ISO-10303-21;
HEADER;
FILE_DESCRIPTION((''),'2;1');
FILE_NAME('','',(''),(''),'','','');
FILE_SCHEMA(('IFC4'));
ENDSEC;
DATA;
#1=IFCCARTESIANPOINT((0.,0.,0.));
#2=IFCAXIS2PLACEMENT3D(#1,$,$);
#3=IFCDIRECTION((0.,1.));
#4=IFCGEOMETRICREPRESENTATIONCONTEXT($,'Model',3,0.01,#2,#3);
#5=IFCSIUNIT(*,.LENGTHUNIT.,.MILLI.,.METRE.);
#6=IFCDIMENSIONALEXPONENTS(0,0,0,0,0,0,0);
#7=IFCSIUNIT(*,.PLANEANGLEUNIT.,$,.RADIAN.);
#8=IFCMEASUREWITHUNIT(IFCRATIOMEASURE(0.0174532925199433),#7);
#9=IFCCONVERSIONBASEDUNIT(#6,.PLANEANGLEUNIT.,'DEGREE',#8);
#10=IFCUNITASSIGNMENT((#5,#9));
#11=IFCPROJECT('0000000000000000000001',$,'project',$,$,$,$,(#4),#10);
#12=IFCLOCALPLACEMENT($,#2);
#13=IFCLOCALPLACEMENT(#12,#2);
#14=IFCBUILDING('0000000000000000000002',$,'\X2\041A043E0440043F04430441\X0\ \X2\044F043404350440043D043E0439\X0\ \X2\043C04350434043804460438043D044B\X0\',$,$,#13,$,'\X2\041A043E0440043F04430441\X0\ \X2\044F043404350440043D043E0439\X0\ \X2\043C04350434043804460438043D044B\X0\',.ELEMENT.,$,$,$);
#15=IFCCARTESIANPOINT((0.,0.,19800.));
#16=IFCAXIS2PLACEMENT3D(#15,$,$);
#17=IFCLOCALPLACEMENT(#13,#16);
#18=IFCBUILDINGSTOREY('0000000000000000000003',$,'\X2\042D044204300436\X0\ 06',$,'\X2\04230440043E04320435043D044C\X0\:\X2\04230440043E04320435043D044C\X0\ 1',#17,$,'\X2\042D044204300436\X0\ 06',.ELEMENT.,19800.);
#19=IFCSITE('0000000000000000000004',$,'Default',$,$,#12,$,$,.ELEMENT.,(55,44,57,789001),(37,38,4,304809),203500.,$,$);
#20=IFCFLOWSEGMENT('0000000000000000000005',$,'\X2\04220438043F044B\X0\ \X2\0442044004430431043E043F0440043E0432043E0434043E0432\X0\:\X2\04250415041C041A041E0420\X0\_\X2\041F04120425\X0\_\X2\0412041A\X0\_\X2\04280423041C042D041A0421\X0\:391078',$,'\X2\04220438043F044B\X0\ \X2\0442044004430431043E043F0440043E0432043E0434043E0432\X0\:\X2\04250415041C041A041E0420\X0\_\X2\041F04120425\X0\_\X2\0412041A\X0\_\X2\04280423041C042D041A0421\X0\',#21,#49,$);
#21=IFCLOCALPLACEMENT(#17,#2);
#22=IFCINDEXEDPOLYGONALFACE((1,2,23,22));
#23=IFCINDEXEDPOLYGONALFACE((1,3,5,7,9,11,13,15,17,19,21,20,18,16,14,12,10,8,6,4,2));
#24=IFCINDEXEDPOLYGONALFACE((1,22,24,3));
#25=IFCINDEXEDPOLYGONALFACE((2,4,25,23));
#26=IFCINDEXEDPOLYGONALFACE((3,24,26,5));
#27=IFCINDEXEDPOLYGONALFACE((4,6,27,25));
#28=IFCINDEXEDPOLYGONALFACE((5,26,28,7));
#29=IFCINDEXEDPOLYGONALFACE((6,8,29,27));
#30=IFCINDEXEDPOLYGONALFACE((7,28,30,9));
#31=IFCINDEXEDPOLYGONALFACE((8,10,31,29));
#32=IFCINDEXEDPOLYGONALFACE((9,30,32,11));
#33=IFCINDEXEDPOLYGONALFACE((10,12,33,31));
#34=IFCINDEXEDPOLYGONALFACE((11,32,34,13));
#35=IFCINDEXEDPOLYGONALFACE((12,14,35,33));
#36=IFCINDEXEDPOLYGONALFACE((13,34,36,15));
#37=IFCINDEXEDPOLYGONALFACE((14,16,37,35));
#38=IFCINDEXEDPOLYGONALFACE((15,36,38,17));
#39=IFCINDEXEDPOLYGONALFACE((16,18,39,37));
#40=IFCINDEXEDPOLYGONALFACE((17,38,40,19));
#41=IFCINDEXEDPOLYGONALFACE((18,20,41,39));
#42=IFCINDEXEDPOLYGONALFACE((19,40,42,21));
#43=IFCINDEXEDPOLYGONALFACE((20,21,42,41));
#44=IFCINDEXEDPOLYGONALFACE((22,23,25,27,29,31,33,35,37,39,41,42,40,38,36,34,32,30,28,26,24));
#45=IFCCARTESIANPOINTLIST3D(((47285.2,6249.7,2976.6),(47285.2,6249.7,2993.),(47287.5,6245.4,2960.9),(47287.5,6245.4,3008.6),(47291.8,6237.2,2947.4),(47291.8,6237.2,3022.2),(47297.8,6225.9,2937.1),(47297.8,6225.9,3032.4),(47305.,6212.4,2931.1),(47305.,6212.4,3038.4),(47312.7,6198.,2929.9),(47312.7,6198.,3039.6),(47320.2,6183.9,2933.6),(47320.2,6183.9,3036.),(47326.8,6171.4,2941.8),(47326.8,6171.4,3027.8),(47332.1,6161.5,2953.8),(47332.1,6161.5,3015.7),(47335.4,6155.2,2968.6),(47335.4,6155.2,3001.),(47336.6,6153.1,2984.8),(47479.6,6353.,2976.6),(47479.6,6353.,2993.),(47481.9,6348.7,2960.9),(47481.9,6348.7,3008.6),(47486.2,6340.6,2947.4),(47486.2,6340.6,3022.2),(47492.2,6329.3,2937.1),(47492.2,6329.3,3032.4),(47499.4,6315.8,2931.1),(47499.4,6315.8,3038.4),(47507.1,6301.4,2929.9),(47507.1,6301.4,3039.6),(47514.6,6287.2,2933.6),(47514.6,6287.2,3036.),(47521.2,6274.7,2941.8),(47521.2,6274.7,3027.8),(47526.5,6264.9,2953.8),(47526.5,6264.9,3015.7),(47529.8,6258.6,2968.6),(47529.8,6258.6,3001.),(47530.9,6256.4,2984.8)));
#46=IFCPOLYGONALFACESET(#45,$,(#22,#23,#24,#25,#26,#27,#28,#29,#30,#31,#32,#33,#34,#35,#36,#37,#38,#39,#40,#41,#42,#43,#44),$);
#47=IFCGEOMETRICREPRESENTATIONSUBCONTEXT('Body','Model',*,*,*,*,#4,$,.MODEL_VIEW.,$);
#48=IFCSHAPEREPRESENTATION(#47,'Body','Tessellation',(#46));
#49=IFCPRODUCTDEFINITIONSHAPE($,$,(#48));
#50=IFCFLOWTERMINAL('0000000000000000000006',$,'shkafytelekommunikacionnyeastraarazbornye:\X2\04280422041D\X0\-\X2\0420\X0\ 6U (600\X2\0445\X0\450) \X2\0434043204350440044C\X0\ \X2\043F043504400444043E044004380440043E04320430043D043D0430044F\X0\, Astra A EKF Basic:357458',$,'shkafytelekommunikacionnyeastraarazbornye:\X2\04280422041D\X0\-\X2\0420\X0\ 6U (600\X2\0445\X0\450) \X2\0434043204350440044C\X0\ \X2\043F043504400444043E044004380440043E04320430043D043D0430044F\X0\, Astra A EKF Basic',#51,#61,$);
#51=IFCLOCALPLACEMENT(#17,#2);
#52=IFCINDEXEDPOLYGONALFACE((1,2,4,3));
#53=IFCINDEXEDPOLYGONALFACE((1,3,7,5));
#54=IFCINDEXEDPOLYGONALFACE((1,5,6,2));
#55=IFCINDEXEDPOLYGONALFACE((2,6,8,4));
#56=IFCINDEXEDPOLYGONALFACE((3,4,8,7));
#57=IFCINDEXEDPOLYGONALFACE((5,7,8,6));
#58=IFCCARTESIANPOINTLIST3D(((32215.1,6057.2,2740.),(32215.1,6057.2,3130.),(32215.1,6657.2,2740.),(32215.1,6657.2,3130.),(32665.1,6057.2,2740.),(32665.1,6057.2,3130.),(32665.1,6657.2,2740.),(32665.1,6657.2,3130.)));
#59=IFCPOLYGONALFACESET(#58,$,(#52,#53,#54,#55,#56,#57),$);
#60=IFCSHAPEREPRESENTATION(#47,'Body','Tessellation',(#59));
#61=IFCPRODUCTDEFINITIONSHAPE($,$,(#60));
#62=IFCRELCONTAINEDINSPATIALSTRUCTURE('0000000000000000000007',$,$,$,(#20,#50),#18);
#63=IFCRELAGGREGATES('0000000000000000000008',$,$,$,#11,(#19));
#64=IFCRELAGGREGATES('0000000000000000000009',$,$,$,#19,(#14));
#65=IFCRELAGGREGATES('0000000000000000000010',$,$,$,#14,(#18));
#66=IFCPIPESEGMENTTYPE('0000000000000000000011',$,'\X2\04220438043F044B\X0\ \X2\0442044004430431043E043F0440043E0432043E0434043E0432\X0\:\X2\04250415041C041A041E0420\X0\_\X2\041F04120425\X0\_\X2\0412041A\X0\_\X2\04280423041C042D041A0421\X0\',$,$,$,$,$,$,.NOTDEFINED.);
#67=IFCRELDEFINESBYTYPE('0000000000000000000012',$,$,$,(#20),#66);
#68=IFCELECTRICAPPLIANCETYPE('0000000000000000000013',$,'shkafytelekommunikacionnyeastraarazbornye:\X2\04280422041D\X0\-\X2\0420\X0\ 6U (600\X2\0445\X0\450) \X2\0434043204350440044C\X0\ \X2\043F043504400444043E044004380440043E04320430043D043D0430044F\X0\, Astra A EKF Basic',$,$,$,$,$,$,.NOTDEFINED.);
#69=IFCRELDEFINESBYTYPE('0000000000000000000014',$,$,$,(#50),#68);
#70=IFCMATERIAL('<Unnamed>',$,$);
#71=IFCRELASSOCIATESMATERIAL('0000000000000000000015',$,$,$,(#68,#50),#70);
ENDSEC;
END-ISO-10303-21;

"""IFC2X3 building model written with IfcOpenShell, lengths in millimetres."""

from ifc_helpers import new_model, entity, si_unit, converted_unit, direction, frame, frame_2d, origin, origin_2d_with_axis, place, context, subcontext, project, spatial, rectangle, circle, extrude, source, transform, mapped, material, type_object, type_shapes, element, save


model = new_model("IFC2X3")

# Units and contexts
model_context = context("Model", 3, precision=0.01, world=origin(), true_north=direction((0.0, 1.0)))
body_context = subcontext(model_context, "Body", "Model", "MODEL_VIEW")
ifc_project = project(units=[si_unit("LENGTHUNIT", "METRE", prefix="MILLI"), converted_unit("PLANEANGLEUNIT", "DEGREE", entity("IfcRatioMeasure", 0.0174532925199433), si_unit("PLANEANGLEUNIT", "RADIAN"), dimensions=[0, 0, 0, 0, 0, 0, 0])], contexts=[model_context])

# Site, building, storey
site_placement = place(None, frame((0.0, 0.0, 0.0)))
site = spatial("IfcSite", under=ifc_project, at=site_placement, Name="Default", CompositionType="ELEMENT", RefLatitude=(55, 44, 57, 789001), RefLongitude=(37, 38, 4, 304809), RefElevation=203500.0)
building_placement = place(site_placement, origin())
building = spatial("IfcBuilding", under=site, at=building_placement, Name="Корпус ядерной медицины", LongName="Корпус ядерной медицины", CompositionType="ELEMENT")
storey_placement = place(building_placement, frame((0.0, 0.0, 19800.0)))
storey = spatial("IfcBuildingStorey", under=building, at=storey_placement, Name="Этаж 06", ObjectType="Уровень:Уровень 1", LongName="Этаж 06", CompositionType="ELEMENT", Elevation=19800.0)

# Flow segment
pipe_segment_type = type_object("IfcPipeSegmentType", Name="Типы трубопроводов:ХЕМКОР_ПВХ_ВК_ШУМЭКС", PredefinedType="NOTDEFINED")
flow_segment_1_placement = place(storey_placement, frame((47283.3, 6151.5, 2928.2)))
element("IfcFlowSegment", 1, at=flow_segment_1_placement, inside=storey, type_object=pipe_segment_type, Name="Типы трубопроводов:ХЕМКОР_ПВХ_ВК_ШУМЭКС:391078", ObjectType="Типы трубопроводов:ХЕМКОР_ПВХ_ВК_ШУМЭКС", context=body_context, shape_type="SweptSolid", body=[
    extrude(circle(Radius=55.0, at=frame_2d((0.0, 0.0), x_axis=(1.0, 0.0))), frame((27.4, 50.2, 56.6), z_axis=(0.882948, 0.469472, 0.0), x_axis=(0.469472, -0.882948, 0.0)), (0.0, 0.0, 1.0), 220.1),
])

# Flow terminal
ifc_material = material(Name="<Unnamed>")
electric_appliance_type = type_object("IfcElectricApplianceType", Name="shkafytelekommunikacionnyeastraarazbornye:ШТН-Р 6U (600х450) дверь перфорированная, Astra A EKF Basic", PredefinedType="TELEPHONE", material=ifc_material)
shared_shape = source(origin(), body_context, "Body", "SweptSolid", [
    extrude(rectangle(XDim=600.0, YDim=450.0, at=origin_2d_with_axis()), frame((0.0, 0.0, 0.0), z_axis=(0.0, 0.0, 1.0), x_axis=(-1.0, 0.0, 0.0)), (0.0, 0.0, 1.0), 390.0),
])
type_shapes(electric_appliance_type, [shared_shape])
flow_terminal_placement = place(storey_placement, frame((32440.1, 6357.2, 2740.0), z_axis=(0.0, 0.0, 1.0), x_axis=(0.0, 1.0, 0.0)))
element("IfcFlowTerminal", 2, at=flow_terminal_placement, inside=storey, type_object=electric_appliance_type, material=ifc_material, Name="shkafytelekommunikacionnyeastraarazbornye:ШТН-Р 6U (600х450) дверь перфорированная, Astra A EKF Basic:357458", ObjectType="shkafytelekommunikacionnyeastraarazbornye:ШТН-Р 6U (600х450) дверь перфорированная, Astra A EKF Basic", context=body_context, shape_type="MappedRepresentation", body=[
    mapped(shared_shape, transform((0.0, 0.0, 0.0), scale=1.0)),
])

save(model, "model.ifc")
